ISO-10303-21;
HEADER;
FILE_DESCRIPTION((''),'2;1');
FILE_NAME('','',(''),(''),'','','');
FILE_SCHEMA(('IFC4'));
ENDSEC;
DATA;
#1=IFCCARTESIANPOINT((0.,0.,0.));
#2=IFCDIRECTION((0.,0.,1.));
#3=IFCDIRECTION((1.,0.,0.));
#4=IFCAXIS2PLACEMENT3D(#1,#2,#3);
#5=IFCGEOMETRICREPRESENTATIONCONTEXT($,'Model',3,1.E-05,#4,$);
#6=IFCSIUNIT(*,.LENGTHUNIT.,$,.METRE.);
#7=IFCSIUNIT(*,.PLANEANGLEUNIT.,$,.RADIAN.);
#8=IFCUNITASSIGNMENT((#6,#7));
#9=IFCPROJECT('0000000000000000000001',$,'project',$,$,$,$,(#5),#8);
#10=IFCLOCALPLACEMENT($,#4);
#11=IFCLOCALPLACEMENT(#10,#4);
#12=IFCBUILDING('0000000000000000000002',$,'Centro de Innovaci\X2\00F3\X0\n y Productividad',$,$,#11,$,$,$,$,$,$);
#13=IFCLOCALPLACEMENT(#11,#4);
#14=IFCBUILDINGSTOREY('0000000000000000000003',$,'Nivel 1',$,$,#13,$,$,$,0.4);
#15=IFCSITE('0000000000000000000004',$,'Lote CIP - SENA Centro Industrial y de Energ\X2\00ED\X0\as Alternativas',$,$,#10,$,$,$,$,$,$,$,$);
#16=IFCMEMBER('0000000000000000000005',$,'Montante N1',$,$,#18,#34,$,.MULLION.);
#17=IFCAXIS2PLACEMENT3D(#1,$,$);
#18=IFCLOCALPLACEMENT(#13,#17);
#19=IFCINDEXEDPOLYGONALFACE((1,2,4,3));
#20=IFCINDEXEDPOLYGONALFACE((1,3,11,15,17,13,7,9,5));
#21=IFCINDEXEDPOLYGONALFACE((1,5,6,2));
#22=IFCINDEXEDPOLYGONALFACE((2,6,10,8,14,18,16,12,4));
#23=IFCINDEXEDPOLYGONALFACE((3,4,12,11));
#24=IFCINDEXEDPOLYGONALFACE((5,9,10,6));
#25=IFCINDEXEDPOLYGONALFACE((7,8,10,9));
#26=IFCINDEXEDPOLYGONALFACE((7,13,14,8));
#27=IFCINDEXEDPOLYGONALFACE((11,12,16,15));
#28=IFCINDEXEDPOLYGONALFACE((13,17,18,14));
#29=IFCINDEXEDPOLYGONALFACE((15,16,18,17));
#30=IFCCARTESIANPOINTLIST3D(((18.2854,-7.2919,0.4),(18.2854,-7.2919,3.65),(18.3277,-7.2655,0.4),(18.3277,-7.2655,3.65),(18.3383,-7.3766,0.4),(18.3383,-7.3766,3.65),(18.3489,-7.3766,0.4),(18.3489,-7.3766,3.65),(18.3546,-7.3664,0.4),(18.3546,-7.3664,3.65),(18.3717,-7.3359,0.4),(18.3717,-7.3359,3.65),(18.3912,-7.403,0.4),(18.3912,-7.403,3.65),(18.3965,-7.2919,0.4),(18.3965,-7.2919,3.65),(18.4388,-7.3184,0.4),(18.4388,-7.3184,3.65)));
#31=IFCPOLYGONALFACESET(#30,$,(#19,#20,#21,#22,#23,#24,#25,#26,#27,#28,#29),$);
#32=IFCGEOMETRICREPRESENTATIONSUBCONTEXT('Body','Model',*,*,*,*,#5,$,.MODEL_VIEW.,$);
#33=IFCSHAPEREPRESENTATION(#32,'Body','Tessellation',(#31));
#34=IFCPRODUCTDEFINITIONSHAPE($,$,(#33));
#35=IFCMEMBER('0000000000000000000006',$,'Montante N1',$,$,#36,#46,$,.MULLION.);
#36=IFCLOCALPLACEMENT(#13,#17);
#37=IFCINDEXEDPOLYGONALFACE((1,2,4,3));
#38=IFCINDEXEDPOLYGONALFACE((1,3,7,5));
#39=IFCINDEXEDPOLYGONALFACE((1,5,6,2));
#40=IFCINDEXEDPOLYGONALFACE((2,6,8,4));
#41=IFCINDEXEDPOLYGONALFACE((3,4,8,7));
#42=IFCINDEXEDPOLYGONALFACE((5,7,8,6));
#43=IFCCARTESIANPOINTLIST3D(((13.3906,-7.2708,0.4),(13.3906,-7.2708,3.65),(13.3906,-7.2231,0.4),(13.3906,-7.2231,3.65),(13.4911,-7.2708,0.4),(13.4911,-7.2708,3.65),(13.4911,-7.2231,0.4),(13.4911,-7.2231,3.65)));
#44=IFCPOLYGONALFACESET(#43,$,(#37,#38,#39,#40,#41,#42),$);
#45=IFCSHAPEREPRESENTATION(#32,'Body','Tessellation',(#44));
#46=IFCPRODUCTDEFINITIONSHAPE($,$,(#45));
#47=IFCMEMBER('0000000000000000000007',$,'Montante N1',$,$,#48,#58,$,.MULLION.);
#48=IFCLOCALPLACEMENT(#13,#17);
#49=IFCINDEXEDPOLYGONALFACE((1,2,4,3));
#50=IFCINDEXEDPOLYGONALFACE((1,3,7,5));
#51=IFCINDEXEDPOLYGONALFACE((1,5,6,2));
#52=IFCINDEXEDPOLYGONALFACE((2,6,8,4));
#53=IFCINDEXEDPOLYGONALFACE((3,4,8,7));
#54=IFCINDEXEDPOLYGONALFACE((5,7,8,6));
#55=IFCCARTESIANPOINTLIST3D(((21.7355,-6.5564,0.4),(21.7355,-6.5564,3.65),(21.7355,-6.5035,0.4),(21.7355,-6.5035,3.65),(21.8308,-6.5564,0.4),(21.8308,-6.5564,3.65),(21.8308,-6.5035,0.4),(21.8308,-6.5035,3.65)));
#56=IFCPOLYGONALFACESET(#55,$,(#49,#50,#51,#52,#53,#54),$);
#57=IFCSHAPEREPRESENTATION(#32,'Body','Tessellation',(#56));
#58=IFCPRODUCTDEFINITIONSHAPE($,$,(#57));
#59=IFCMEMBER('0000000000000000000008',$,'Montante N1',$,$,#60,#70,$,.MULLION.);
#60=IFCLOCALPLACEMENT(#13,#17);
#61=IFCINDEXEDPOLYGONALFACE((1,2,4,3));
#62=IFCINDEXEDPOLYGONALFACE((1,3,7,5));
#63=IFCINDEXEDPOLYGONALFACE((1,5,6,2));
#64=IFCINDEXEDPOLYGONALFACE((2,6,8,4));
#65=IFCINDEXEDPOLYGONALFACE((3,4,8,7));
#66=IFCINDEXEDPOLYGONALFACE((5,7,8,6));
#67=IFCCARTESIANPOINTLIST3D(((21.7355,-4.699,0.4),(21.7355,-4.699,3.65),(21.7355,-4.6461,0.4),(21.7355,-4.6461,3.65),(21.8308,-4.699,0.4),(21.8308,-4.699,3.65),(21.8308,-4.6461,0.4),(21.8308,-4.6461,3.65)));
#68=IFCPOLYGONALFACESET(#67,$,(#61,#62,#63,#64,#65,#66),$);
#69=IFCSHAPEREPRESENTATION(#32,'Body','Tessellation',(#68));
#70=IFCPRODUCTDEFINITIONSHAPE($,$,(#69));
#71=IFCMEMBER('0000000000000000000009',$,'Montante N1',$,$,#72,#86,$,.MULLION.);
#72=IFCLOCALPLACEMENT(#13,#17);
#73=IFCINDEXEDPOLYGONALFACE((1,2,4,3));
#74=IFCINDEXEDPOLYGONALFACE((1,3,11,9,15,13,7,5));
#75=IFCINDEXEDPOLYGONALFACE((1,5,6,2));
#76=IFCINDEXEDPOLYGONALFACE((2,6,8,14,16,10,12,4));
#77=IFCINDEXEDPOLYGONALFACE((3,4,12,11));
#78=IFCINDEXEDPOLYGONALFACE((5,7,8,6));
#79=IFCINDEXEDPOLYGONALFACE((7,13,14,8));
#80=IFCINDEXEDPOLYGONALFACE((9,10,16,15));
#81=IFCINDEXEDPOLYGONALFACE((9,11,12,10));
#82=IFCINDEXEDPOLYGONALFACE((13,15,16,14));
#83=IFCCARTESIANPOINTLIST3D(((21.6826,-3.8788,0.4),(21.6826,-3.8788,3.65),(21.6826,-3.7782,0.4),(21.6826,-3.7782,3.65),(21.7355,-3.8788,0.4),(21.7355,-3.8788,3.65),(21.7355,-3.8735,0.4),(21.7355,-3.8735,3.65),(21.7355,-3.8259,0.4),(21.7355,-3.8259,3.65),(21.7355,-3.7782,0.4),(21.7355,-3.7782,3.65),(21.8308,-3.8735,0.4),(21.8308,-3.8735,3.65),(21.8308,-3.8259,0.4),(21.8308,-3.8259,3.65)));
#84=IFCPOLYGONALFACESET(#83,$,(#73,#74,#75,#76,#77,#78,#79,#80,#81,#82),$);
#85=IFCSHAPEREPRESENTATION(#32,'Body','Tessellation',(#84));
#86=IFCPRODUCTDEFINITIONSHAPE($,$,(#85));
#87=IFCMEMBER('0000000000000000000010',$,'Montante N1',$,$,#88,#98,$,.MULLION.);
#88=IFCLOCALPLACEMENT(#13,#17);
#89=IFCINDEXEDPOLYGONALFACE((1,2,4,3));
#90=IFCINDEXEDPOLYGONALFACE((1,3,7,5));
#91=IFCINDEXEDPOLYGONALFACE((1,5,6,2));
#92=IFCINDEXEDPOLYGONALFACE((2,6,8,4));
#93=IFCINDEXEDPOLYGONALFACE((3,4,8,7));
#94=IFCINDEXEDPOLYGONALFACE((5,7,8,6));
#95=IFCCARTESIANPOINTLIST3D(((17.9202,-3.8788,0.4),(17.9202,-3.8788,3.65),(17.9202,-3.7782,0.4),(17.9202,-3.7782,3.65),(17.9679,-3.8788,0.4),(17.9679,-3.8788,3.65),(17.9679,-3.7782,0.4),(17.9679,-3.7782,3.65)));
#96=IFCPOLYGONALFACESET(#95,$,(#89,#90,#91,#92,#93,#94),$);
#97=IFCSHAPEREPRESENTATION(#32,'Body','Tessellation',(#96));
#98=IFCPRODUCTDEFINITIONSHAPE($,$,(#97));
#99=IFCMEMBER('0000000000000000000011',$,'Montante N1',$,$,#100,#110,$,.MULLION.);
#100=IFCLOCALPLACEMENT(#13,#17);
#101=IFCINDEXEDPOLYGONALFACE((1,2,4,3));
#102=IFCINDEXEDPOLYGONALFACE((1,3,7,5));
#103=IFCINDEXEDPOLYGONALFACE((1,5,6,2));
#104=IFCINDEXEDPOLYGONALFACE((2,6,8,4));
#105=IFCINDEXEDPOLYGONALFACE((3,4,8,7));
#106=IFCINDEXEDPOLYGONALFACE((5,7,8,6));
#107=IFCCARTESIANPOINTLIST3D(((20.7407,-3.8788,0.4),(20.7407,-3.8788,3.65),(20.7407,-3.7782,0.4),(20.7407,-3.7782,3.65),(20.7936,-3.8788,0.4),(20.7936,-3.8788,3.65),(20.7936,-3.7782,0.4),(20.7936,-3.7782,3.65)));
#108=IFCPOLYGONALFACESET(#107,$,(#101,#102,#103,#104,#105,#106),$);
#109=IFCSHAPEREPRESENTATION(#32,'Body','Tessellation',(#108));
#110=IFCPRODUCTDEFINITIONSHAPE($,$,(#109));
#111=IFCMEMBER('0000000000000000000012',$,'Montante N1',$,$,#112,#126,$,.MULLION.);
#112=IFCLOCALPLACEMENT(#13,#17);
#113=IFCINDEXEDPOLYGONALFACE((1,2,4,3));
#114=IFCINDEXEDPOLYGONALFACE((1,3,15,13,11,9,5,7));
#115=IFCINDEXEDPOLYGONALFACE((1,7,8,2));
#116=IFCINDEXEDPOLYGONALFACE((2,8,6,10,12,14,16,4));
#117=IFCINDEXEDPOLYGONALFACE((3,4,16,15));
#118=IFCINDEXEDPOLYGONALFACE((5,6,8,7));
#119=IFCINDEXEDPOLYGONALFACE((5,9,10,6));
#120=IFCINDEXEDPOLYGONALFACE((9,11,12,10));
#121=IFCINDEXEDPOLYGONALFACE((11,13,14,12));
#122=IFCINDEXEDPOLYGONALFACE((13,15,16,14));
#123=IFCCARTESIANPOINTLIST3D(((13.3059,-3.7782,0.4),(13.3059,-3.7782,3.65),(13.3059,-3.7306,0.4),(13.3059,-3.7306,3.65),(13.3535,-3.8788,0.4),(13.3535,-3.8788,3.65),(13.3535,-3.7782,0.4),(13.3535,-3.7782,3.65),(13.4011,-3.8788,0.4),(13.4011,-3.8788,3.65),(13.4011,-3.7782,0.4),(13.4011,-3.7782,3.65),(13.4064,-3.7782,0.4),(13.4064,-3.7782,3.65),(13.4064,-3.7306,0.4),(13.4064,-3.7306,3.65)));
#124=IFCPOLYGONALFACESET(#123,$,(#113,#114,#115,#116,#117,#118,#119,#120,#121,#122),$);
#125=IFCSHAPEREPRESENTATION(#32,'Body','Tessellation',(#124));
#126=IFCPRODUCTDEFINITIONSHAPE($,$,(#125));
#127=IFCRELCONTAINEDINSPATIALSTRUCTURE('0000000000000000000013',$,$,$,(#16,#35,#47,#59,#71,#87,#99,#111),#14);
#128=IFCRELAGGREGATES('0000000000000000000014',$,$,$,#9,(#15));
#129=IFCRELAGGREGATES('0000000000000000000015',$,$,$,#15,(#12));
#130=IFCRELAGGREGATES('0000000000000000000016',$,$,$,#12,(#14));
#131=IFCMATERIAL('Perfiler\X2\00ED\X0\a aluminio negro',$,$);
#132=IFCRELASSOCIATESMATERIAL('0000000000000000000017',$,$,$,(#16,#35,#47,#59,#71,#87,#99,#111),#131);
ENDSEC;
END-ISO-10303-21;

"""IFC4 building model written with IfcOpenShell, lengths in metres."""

from ifc_helpers import new_model, si_unit, frame, origin_with_axes, place, context, subcontext, project, spatial, polyline, outline, extrude, material, element, save


model = new_model("IFC4")

# Units and contexts
model_context = context("Model", 3, precision=1e-05, world=origin_with_axes())
body_context = subcontext(model_context, "Body", "Model", "MODEL_VIEW")
ifc_project = project(units=[si_unit("LENGTHUNIT", "METRE"), si_unit("PLANEANGLEUNIT", "RADIAN")], contexts=[model_context])

# Site, building, storey
site_placement = place(None, origin_with_axes())
site = spatial("IfcSite", under=ifc_project, at=site_placement, Name="Lote CIP - SENA Centro Industrial y de Energías Alternativas")
building_placement = place(site_placement, origin_with_axes())
building = spatial("IfcBuilding", under=site, at=building_placement, Name="Centro de Innovación y Productividad")
storey_placement = place(building_placement, origin_with_axes())
storey = spatial("IfcBuildingStorey", under=building, at=storey_placement, Name="Nivel 1", Elevation=0.4)

# Members
ifc_material = material(Name="Perfilería aluminio negro")
member_1_placement = place(storey_placement, origin_with_axes())
element("IfcMember", 1, at=member_1_placement, inside=storey, material=ifc_material, Name="Montante N1", PredefinedType="MULLION", context=body_context, shape_type="SweptSolid", body=[
    extrude(outline(polyline([(18.3965, -7.2919), (18.4388, -7.3184), (18.3912, -7.403), (18.3489, -7.3766), (18.3546, -7.3664), (18.3383, -7.3766), (18.2854, -7.2919), (18.3277, -7.2655), (18.3717, -7.3359), (18.3965, -7.2919)])), frame((0.0, 0.0, 0.4)), (0.0, 0.0, 1.0), 3.25),
])
member_2_placement = place(storey_placement, origin_with_axes())
element("IfcMember", 2, at=member_2_placement, inside=storey, material=ifc_material, Name="Montante N1", PredefinedType="MULLION", context=body_context, shape_type="SweptSolid", body=[
    extrude(outline(polyline([(13.4911, -7.2231), (13.4911, -7.2708), (13.3906, -7.2708), (13.3906, -7.2231), (13.4911, -7.2231)])), frame((0.0, 0.0, 0.4)), (0.0, 0.0, 1.0), 3.25),
])
member_3_placement = place(storey_placement, origin_with_axes())
element("IfcMember", 3, at=member_3_placement, inside=storey, material=ifc_material, Name="Montante N1", PredefinedType="MULLION", context=body_context, shape_type="SweptSolid", body=[
    extrude(outline(polyline([(21.7355, -6.5035), (21.8308, -6.5035), (21.8308, -6.5564), (21.7355, -6.5564), (21.7355, -6.5035)])), frame((0.0, 0.0, 0.4)), (0.0, 0.0, 1.0), 3.25),
])
member_4_placement = place(storey_placement, origin_with_axes())
element("IfcMember", 4, at=member_4_placement, inside=storey, material=ifc_material, Name="Montante N1", PredefinedType="MULLION", context=body_context, shape_type="SweptSolid", body=[
    extrude(outline(polyline([(21.7355, -4.699), (21.7355, -4.6461), (21.8308, -4.6461), (21.8308, -4.699), (21.7355, -4.699)])), frame((0.0, 0.0, 0.4)), (0.0, 0.0, 1.0), 3.25),
])
member_5_placement = place(storey_placement, origin_with_axes())
element("IfcMember", 5, at=member_5_placement, inside=storey, material=ifc_material, Name="Montante N1", PredefinedType="MULLION", context=body_context, shape_type="SweptSolid", body=[
    extrude(outline(polyline([(21.7355, -3.7782), (21.7355, -3.8259), (21.8308, -3.8259), (21.8308, -3.8735), (21.7355, -3.8735), (21.7355, -3.8788), (21.6826, -3.8788), (21.6826, -3.7782), (21.7355, -3.7782)])), frame((0.0, 0.0, 0.4)), (0.0, 0.0, 1.0), 3.25),
])
member_6_placement = place(storey_placement, origin_with_axes())
element("IfcMember", 6, at=member_6_placement, inside=storey, material=ifc_material, Name="Montante N1", PredefinedType="MULLION", context=body_context, shape_type="SweptSolid", body=[
    extrude(outline(polyline([(17.9679, -3.8788), (17.9202, -3.8788), (17.9202, -3.7782), (17.9679, -3.7782), (17.9679, -3.8788)])), frame((0.0, 0.0, 0.4)), (0.0, 0.0, 1.0), 3.25),
])
member_7_placement = place(storey_placement, origin_with_axes())
element("IfcMember", 7, at=member_7_placement, inside=storey, material=ifc_material, Name="Montante N1", PredefinedType="MULLION", context=body_context, shape_type="SweptSolid", body=[
    extrude(outline(polyline([(20.7936, -3.7782), (20.7936, -3.8788), (20.7407, -3.8788), (20.7407, -3.7782), (20.7936, -3.7782)])), frame((0.0, 0.0, 0.4)), (0.0, 0.0, 1.0), 3.25),
])
member_8_placement = place(storey_placement, origin_with_axes())
element("IfcMember", 8, at=member_8_placement, inside=storey, material=ifc_material, Name="Montante N1", PredefinedType="MULLION", context=body_context, shape_type="SweptSolid", body=[
    extrude(outline(polyline([(13.4064, -3.7782), (13.4011, -3.7782), (13.4011, -3.8788), (13.3535, -3.8788), (13.3535, -3.7782), (13.3059, -3.7782), (13.3059, -3.7306), (13.4064, -3.7306), (13.4064, -3.7782)])), frame((0.0, 0.0, 0.4)), (0.0, 0.0, 1.0), 3.25),
])

save(model, "model.ifc")
